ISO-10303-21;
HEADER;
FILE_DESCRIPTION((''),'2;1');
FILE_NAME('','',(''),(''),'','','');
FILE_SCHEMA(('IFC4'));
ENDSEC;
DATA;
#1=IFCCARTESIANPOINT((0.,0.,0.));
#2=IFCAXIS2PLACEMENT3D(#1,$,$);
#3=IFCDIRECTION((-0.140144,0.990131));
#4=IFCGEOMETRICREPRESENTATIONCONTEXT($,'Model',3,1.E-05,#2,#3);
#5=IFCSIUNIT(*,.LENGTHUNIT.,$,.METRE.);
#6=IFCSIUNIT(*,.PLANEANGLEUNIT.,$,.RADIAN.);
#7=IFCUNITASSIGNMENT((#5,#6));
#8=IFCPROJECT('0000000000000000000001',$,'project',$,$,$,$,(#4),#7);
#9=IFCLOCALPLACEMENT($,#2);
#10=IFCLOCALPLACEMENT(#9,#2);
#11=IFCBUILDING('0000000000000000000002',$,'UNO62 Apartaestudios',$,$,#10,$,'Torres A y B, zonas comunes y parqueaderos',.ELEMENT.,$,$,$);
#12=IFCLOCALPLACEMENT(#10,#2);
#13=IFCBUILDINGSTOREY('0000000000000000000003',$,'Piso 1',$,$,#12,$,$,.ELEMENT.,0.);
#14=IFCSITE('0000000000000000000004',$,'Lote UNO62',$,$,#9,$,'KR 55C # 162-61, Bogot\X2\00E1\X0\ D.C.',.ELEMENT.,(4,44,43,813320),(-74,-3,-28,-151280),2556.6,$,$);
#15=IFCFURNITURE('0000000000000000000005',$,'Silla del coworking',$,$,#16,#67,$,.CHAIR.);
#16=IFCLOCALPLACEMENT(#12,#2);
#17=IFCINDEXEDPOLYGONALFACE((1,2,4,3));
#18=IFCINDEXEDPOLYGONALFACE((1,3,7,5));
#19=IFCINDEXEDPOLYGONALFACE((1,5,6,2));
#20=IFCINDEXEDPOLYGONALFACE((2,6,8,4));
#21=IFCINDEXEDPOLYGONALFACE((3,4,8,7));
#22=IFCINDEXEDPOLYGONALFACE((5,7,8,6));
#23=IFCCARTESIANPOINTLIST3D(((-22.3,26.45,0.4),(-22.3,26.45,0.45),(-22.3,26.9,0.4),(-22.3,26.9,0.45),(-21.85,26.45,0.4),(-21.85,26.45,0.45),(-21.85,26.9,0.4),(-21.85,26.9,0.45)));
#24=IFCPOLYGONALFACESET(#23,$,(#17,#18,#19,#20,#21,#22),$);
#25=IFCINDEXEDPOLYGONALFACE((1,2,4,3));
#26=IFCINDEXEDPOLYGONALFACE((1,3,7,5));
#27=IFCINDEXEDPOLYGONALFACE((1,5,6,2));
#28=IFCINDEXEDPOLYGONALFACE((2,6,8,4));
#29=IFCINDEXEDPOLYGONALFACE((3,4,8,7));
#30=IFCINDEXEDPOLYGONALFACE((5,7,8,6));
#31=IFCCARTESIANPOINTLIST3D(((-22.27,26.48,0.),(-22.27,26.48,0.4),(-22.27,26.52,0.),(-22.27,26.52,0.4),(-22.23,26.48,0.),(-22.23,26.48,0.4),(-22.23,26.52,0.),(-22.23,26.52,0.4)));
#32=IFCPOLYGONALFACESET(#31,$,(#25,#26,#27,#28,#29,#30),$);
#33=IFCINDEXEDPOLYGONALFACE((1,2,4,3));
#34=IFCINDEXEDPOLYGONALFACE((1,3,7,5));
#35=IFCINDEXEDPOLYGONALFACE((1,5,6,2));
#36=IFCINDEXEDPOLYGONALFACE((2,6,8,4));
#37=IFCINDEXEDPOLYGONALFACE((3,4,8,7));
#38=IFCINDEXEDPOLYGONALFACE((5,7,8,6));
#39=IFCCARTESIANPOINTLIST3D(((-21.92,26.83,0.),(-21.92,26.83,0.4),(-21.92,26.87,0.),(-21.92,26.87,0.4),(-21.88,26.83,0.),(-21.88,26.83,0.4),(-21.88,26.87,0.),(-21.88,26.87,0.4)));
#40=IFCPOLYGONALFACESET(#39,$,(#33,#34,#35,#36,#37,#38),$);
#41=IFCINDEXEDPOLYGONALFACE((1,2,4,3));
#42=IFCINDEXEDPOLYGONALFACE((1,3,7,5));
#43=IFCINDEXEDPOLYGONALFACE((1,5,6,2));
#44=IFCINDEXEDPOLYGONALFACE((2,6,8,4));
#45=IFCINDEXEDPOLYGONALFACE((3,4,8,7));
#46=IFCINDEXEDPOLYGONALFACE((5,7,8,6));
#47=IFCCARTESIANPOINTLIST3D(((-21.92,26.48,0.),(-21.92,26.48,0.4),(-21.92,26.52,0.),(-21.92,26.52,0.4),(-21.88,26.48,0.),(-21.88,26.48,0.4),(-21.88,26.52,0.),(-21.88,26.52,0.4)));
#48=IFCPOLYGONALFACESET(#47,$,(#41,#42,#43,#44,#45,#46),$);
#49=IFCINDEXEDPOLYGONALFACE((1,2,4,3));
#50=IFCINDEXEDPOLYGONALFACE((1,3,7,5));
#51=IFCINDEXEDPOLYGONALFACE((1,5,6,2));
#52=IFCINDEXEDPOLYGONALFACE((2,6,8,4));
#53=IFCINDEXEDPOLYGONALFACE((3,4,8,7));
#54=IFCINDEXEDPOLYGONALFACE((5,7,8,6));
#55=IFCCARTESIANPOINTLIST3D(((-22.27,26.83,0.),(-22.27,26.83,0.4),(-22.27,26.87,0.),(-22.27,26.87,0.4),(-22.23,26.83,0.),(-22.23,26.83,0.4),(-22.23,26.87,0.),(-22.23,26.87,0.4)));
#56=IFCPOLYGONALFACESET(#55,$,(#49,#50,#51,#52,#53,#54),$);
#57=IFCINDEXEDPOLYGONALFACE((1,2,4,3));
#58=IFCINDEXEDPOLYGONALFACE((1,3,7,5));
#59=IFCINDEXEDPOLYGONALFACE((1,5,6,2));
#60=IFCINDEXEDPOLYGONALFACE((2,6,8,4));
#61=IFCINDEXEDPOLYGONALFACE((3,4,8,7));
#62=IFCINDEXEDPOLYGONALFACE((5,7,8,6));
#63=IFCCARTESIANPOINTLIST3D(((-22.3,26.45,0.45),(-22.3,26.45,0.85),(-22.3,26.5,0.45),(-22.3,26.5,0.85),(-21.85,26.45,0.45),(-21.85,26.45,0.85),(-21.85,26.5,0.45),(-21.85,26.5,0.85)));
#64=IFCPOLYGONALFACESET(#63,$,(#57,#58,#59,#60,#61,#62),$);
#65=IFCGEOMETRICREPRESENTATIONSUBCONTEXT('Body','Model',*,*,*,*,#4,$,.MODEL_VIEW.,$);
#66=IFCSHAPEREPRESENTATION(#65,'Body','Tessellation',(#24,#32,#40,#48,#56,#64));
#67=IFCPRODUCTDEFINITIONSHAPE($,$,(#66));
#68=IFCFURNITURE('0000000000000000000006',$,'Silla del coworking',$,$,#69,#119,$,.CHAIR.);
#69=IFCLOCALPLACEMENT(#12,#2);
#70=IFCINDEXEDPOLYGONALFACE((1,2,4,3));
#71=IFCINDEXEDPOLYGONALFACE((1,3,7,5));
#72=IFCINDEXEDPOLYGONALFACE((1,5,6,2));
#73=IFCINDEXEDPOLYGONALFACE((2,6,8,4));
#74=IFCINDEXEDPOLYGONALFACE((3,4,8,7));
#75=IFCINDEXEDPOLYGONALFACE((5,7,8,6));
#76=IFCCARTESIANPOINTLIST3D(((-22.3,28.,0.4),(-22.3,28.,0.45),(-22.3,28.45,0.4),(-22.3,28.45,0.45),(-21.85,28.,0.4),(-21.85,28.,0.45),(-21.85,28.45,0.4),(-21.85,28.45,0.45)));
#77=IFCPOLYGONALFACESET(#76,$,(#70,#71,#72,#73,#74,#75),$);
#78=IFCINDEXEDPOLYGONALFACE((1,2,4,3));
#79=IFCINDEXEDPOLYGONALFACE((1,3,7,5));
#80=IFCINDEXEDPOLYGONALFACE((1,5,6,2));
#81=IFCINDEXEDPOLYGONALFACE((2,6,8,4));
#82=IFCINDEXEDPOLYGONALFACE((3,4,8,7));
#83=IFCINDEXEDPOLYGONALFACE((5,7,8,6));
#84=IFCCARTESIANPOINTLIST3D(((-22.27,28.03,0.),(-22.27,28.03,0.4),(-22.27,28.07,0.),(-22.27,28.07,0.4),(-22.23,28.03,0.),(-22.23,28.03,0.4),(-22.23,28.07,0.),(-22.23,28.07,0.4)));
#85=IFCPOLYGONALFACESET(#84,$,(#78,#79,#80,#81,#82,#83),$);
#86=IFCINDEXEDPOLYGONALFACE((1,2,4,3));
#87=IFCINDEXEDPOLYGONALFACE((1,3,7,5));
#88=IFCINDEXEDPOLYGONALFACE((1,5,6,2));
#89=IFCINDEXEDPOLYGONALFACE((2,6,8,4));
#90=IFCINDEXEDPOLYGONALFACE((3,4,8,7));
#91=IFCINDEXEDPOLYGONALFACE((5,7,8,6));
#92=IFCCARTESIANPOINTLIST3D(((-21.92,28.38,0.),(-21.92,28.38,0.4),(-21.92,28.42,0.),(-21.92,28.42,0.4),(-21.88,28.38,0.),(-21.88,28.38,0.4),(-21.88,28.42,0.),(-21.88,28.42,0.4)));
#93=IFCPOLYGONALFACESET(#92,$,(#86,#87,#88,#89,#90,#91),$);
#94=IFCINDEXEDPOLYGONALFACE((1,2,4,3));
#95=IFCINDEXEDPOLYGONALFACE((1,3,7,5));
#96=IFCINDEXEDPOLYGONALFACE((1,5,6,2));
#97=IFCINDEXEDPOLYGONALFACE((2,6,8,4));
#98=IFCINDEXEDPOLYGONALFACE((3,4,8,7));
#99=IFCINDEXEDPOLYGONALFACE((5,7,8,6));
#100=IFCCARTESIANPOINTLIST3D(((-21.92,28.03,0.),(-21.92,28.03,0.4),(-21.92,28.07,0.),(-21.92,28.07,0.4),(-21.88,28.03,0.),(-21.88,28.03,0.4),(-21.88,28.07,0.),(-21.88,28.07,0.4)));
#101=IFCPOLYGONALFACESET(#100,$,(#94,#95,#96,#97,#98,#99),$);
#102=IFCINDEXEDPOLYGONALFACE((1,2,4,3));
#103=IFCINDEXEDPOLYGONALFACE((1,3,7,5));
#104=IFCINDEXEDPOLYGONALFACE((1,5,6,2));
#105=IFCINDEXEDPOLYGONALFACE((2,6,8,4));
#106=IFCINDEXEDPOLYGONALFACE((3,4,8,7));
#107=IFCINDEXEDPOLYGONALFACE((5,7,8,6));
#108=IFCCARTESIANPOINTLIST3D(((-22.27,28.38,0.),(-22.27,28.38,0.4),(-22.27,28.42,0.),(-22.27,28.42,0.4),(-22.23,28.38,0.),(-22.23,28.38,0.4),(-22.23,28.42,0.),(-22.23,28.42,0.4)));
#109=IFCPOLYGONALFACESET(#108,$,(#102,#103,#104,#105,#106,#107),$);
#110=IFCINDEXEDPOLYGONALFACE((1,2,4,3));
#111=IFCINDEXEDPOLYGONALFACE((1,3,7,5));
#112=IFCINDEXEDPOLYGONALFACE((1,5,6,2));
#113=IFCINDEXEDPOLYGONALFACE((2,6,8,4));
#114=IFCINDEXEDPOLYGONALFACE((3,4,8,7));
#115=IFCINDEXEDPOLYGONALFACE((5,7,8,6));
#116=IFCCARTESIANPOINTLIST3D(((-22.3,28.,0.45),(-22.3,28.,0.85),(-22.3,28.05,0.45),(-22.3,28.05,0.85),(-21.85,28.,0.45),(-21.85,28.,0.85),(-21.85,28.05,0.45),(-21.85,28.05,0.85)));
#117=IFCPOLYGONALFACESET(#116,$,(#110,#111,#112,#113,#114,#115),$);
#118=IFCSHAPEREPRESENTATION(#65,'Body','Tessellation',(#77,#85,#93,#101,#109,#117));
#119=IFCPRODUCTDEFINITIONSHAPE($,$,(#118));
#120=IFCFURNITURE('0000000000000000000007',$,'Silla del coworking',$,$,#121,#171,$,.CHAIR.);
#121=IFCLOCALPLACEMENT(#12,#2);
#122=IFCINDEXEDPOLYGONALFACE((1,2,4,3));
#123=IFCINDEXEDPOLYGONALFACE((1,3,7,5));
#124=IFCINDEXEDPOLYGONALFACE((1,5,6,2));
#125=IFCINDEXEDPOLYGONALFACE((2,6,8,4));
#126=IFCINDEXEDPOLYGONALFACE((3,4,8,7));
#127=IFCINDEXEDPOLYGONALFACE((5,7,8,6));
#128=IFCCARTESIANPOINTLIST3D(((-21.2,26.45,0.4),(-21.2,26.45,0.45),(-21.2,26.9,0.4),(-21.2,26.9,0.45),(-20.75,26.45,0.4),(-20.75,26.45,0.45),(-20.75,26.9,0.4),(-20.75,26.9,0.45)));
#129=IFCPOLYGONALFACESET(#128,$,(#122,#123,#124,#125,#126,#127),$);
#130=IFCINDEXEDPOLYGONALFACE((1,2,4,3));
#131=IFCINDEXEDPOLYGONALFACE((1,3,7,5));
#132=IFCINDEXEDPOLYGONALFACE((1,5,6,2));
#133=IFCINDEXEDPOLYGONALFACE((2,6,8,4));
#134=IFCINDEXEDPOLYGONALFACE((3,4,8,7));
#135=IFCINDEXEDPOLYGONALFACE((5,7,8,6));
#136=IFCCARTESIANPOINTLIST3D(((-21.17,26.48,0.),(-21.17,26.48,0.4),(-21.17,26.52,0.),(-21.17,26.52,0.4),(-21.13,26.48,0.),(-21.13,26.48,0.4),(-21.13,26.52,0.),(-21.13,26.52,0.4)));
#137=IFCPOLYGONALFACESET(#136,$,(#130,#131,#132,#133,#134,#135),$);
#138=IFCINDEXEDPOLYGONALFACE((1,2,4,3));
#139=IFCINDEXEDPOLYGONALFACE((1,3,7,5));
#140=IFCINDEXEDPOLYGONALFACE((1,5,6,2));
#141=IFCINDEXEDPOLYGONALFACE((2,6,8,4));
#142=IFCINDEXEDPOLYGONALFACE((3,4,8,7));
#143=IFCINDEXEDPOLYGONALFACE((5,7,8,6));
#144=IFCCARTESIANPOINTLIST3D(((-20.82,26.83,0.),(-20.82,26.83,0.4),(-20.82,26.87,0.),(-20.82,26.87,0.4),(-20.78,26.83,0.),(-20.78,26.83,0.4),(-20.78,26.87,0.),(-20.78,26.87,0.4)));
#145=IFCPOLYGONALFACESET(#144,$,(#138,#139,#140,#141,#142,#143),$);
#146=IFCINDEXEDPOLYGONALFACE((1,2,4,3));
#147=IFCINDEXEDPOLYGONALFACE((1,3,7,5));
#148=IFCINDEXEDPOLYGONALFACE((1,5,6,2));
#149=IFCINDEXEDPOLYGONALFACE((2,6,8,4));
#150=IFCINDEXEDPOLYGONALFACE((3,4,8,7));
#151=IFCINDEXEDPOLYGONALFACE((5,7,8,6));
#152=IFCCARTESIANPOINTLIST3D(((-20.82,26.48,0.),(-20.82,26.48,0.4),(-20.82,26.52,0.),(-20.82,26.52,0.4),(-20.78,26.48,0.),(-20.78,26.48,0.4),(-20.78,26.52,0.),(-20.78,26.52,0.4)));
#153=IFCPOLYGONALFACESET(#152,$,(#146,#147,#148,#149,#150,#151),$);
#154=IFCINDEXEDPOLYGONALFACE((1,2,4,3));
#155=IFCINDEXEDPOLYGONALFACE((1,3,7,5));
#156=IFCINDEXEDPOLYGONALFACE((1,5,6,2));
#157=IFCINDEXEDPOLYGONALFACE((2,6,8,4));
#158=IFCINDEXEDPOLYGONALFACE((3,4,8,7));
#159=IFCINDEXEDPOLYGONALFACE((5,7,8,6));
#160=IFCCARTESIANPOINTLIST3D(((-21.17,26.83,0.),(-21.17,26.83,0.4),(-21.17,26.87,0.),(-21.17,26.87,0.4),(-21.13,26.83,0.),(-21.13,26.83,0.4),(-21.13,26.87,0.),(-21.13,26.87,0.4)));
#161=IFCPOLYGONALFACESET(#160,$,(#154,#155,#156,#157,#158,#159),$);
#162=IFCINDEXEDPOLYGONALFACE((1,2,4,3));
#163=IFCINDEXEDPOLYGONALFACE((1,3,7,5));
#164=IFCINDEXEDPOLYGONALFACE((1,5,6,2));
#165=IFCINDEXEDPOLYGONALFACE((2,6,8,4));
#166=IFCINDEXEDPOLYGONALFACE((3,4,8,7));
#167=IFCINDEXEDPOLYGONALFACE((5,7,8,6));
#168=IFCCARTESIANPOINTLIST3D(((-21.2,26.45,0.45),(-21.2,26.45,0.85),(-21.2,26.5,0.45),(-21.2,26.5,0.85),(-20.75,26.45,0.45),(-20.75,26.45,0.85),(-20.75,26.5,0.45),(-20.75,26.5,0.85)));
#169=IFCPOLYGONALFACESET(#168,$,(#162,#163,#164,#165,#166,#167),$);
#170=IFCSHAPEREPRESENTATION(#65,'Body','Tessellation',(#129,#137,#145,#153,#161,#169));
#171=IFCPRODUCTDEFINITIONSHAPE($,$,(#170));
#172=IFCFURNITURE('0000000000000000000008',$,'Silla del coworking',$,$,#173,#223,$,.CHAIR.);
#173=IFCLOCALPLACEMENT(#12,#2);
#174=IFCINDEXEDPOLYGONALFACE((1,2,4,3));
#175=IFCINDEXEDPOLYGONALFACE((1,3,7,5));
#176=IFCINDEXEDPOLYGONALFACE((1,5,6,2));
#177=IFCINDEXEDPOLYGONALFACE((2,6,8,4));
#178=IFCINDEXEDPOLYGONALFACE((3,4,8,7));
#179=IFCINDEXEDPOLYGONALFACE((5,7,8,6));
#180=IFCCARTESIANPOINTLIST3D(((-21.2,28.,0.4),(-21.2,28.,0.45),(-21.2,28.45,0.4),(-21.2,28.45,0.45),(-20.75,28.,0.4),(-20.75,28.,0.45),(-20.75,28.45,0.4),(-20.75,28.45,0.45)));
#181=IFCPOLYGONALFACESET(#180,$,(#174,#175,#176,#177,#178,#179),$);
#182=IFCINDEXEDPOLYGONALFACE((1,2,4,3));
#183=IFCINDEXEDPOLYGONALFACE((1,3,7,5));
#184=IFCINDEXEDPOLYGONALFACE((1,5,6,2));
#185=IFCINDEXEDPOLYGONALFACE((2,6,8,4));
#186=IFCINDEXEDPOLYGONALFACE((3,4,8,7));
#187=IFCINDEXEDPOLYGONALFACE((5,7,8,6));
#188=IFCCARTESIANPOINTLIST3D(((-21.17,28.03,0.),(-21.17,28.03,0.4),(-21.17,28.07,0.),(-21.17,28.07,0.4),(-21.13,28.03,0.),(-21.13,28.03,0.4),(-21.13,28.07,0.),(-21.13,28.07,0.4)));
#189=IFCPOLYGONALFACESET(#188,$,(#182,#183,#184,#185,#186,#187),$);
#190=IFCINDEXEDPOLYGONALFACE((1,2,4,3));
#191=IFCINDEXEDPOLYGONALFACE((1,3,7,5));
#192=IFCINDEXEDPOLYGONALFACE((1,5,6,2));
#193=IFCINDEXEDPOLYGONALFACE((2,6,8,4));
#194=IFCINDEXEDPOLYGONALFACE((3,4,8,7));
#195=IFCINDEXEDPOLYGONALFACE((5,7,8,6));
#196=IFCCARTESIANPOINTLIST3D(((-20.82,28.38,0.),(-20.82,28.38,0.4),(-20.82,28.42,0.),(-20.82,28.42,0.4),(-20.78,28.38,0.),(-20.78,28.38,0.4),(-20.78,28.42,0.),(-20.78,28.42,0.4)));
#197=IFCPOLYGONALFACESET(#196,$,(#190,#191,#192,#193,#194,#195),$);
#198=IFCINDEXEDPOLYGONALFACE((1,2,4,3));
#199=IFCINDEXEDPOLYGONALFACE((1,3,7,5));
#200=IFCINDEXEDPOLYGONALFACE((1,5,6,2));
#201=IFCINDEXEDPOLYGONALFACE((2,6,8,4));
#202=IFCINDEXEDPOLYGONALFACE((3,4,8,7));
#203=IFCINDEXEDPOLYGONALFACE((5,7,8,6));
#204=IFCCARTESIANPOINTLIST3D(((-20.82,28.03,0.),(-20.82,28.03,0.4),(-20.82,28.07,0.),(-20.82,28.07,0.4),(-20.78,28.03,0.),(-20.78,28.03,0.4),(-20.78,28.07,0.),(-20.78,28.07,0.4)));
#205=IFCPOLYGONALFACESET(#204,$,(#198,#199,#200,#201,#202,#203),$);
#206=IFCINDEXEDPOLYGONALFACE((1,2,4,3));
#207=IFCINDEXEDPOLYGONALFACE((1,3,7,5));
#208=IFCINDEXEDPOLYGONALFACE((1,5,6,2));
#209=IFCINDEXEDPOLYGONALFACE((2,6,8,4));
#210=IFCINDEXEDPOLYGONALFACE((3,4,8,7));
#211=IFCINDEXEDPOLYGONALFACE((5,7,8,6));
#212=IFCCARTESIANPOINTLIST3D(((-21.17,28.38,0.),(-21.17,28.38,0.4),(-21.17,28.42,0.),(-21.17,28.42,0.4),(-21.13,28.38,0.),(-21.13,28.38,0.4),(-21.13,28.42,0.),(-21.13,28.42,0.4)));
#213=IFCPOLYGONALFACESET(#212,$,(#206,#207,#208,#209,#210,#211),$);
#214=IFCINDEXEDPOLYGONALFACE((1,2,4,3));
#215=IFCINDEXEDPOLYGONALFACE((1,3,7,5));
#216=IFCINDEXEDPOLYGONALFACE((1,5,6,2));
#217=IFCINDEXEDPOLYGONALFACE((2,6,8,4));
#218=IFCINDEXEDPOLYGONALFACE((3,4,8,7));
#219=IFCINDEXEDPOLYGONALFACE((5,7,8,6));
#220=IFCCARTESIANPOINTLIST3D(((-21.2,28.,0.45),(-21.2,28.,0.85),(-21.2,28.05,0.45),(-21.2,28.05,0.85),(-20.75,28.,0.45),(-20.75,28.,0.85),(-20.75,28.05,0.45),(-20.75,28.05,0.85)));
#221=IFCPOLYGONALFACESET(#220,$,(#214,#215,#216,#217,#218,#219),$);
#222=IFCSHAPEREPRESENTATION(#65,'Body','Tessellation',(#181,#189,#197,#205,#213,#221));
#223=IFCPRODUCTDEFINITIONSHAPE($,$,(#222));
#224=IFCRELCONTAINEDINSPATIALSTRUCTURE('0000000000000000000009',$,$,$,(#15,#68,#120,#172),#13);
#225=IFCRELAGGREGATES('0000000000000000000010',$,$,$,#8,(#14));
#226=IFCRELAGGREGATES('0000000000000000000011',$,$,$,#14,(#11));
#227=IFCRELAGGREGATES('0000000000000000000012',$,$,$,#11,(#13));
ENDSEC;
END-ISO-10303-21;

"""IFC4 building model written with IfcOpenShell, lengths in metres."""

from ifc_helpers import new_model, si_unit, direction, frame, frame_2d, origin, place, context, subcontext, project, spatial, rectangle, extrude, element, save


model = new_model("IFC4")

# Units and contexts
model_context = context("Model", 3, precision=1e-05, world=origin(), true_north=direction((-0.140144, 0.990131)))
body_context = subcontext(model_context, "Body", "Model", "MODEL_VIEW")
ifc_project = project(units=[si_unit("LENGTHUNIT", "METRE"), si_unit("PLANEANGLEUNIT", "RADIAN")], contexts=[model_context])

# Site, building, storey
site_placement = place(None, origin())
site = spatial("IfcSite", under=ifc_project, at=site_placement, Name="Lote UNO62", LongName="KR 55C # 162-61, Bogotá D.C.", CompositionType="ELEMENT", RefLatitude=(4, 44, 43, 813320), RefLongitude=(-74, -3, -28, -151280), RefElevation=2556.6)
building_placement = place(site_placement, origin())
building = spatial("IfcBuilding", under=site, at=building_placement, Name="UNO62 Apartaestudios", LongName="Torres A y B, zonas comunes y parqueaderos", CompositionType="ELEMENT")
storey_placement = place(building_placement, origin())
storey = spatial("IfcBuildingStorey", under=building, at=storey_placement, Name="Piso 1", CompositionType="ELEMENT", Elevation=0.0)

# Furniture
furniture_1_placement = place(storey_placement, origin())
element("IfcFurniture", 1, at=furniture_1_placement, inside=storey, Name="Silla del coworking", PredefinedType="CHAIR", context=body_context, shape_type="SweptSolid", body=[
    extrude(rectangle(XDim=0.45, YDim=0.45, at=frame_2d((-22.075, 26.675))), frame((0.0, 0.0, 0.4)), (0.0, 0.0, 1.0), 0.05),
    extrude(rectangle(XDim=0.04, YDim=0.04, at=frame_2d((-22.25, 26.5))), origin(), (0.0, 0.0, 1.0), 0.4),
    extrude(rectangle(XDim=0.04, YDim=0.04, at=frame_2d((-21.9, 26.85))), origin(), (0.0, 0.0, 1.0), 0.4),
    extrude(rectangle(XDim=0.04, YDim=0.04, at=frame_2d((-21.9, 26.5))), origin(), (0.0, 0.0, 1.0), 0.4),
    extrude(rectangle(XDim=0.04, YDim=0.04, at=frame_2d((-22.25, 26.85))), origin(), (0.0, 0.0, 1.0), 0.4),
    extrude(rectangle(XDim=0.45, YDim=0.05, at=frame_2d((-22.075, 26.475))), frame((0.0, 0.0, 0.45)), (0.0, 0.0, 1.0), 0.4),
])
furniture_2_placement = place(storey_placement, origin())
element("IfcFurniture", 2, at=furniture_2_placement, inside=storey, Name="Silla del coworking", PredefinedType="CHAIR", context=body_context, shape_type="SweptSolid", body=[
    extrude(rectangle(XDim=0.45, YDim=0.45, at=frame_2d((-22.075, 28.225))), frame((0.0, 0.0, 0.4)), (0.0, 0.0, 1.0), 0.05),
    extrude(rectangle(XDim=0.04, YDim=0.04, at=frame_2d((-22.25, 28.05))), origin(), (0.0, 0.0, 1.0), 0.4),
    extrude(rectangle(XDim=0.04, YDim=0.04, at=frame_2d((-21.9, 28.4))), origin(), (0.0, 0.0, 1.0), 0.4),
    extrude(rectangle(XDim=0.04, YDim=0.04, at=frame_2d((-21.9, 28.05))), origin(), (0.0, 0.0, 1.0), 0.4),
    extrude(rectangle(XDim=0.04, YDim=0.04, at=frame_2d((-22.25, 28.4))), origin(), (0.0, 0.0, 1.0), 0.4),
    extrude(rectangle(XDim=0.45, YDim=0.05, at=frame_2d((-22.075, 28.025))), frame((0.0, 0.0, 0.45)), (0.0, 0.0, 1.0), 0.4),
])
furniture_3_placement = place(storey_placement, origin())
element("IfcFurniture", 3, at=furniture_3_placement, inside=storey, Name="Silla del coworking", PredefinedType="CHAIR", context=body_context, shape_type="SweptSolid", body=[
    extrude(rectangle(XDim=0.45, YDim=0.45, at=frame_2d((-20.975, 26.675))), frame((0.0, 0.0, 0.4)), (0.0, 0.0, 1.0), 0.05),
    extrude(rectangle(XDim=0.04, YDim=0.04, at=frame_2d((-21.15, 26.5))), origin(), (0.0, 0.0, 1.0), 0.4),
    extrude(rectangle(XDim=0.04, YDim=0.04, at=frame_2d((-20.8, 26.85))), origin(), (0.0, 0.0, 1.0), 0.4),
    extrude(rectangle(XDim=0.04, YDim=0.04, at=frame_2d((-20.8, 26.5))), origin(), (0.0, 0.0, 1.0), 0.4),
    extrude(rectangle(XDim=0.04, YDim=0.04, at=frame_2d((-21.15, 26.85))), origin(), (0.0, 0.0, 1.0), 0.4),
    extrude(rectangle(XDim=0.45, YDim=0.05, at=frame_2d((-20.975, 26.475))), frame((0.0, 0.0, 0.45)), (0.0, 0.0, 1.0), 0.4),
])
furniture_4_placement = place(storey_placement, origin())
element("IfcFurniture", 4, at=furniture_4_placement, inside=storey, Name="Silla del coworking", PredefinedType="CHAIR", context=body_context, shape_type="SweptSolid", body=[
    extrude(rectangle(XDim=0.45, YDim=0.45, at=frame_2d((-20.975, 28.225))), frame((0.0, 0.0, 0.4)), (0.0, 0.0, 1.0), 0.05),
    extrude(rectangle(XDim=0.04, YDim=0.04, at=frame_2d((-21.15, 28.05))), origin(), (0.0, 0.0, 1.0), 0.4),
    extrude(rectangle(XDim=0.04, YDim=0.04, at=frame_2d((-20.8, 28.4))), origin(), (0.0, 0.0, 1.0), 0.4),
    extrude(rectangle(XDim=0.04, YDim=0.04, at=frame_2d((-20.8, 28.05))), origin(), (0.0, 0.0, 1.0), 0.4),
    extrude(rectangle(XDim=0.04, YDim=0.04, at=frame_2d((-21.15, 28.4))), origin(), (0.0, 0.0, 1.0), 0.4),
    extrude(rectangle(XDim=0.45, YDim=0.05, at=frame_2d((-20.975, 28.025))), frame((0.0, 0.0, 0.45)), (0.0, 0.0, 1.0), 0.4),
])

save(model, "model.ifc")
